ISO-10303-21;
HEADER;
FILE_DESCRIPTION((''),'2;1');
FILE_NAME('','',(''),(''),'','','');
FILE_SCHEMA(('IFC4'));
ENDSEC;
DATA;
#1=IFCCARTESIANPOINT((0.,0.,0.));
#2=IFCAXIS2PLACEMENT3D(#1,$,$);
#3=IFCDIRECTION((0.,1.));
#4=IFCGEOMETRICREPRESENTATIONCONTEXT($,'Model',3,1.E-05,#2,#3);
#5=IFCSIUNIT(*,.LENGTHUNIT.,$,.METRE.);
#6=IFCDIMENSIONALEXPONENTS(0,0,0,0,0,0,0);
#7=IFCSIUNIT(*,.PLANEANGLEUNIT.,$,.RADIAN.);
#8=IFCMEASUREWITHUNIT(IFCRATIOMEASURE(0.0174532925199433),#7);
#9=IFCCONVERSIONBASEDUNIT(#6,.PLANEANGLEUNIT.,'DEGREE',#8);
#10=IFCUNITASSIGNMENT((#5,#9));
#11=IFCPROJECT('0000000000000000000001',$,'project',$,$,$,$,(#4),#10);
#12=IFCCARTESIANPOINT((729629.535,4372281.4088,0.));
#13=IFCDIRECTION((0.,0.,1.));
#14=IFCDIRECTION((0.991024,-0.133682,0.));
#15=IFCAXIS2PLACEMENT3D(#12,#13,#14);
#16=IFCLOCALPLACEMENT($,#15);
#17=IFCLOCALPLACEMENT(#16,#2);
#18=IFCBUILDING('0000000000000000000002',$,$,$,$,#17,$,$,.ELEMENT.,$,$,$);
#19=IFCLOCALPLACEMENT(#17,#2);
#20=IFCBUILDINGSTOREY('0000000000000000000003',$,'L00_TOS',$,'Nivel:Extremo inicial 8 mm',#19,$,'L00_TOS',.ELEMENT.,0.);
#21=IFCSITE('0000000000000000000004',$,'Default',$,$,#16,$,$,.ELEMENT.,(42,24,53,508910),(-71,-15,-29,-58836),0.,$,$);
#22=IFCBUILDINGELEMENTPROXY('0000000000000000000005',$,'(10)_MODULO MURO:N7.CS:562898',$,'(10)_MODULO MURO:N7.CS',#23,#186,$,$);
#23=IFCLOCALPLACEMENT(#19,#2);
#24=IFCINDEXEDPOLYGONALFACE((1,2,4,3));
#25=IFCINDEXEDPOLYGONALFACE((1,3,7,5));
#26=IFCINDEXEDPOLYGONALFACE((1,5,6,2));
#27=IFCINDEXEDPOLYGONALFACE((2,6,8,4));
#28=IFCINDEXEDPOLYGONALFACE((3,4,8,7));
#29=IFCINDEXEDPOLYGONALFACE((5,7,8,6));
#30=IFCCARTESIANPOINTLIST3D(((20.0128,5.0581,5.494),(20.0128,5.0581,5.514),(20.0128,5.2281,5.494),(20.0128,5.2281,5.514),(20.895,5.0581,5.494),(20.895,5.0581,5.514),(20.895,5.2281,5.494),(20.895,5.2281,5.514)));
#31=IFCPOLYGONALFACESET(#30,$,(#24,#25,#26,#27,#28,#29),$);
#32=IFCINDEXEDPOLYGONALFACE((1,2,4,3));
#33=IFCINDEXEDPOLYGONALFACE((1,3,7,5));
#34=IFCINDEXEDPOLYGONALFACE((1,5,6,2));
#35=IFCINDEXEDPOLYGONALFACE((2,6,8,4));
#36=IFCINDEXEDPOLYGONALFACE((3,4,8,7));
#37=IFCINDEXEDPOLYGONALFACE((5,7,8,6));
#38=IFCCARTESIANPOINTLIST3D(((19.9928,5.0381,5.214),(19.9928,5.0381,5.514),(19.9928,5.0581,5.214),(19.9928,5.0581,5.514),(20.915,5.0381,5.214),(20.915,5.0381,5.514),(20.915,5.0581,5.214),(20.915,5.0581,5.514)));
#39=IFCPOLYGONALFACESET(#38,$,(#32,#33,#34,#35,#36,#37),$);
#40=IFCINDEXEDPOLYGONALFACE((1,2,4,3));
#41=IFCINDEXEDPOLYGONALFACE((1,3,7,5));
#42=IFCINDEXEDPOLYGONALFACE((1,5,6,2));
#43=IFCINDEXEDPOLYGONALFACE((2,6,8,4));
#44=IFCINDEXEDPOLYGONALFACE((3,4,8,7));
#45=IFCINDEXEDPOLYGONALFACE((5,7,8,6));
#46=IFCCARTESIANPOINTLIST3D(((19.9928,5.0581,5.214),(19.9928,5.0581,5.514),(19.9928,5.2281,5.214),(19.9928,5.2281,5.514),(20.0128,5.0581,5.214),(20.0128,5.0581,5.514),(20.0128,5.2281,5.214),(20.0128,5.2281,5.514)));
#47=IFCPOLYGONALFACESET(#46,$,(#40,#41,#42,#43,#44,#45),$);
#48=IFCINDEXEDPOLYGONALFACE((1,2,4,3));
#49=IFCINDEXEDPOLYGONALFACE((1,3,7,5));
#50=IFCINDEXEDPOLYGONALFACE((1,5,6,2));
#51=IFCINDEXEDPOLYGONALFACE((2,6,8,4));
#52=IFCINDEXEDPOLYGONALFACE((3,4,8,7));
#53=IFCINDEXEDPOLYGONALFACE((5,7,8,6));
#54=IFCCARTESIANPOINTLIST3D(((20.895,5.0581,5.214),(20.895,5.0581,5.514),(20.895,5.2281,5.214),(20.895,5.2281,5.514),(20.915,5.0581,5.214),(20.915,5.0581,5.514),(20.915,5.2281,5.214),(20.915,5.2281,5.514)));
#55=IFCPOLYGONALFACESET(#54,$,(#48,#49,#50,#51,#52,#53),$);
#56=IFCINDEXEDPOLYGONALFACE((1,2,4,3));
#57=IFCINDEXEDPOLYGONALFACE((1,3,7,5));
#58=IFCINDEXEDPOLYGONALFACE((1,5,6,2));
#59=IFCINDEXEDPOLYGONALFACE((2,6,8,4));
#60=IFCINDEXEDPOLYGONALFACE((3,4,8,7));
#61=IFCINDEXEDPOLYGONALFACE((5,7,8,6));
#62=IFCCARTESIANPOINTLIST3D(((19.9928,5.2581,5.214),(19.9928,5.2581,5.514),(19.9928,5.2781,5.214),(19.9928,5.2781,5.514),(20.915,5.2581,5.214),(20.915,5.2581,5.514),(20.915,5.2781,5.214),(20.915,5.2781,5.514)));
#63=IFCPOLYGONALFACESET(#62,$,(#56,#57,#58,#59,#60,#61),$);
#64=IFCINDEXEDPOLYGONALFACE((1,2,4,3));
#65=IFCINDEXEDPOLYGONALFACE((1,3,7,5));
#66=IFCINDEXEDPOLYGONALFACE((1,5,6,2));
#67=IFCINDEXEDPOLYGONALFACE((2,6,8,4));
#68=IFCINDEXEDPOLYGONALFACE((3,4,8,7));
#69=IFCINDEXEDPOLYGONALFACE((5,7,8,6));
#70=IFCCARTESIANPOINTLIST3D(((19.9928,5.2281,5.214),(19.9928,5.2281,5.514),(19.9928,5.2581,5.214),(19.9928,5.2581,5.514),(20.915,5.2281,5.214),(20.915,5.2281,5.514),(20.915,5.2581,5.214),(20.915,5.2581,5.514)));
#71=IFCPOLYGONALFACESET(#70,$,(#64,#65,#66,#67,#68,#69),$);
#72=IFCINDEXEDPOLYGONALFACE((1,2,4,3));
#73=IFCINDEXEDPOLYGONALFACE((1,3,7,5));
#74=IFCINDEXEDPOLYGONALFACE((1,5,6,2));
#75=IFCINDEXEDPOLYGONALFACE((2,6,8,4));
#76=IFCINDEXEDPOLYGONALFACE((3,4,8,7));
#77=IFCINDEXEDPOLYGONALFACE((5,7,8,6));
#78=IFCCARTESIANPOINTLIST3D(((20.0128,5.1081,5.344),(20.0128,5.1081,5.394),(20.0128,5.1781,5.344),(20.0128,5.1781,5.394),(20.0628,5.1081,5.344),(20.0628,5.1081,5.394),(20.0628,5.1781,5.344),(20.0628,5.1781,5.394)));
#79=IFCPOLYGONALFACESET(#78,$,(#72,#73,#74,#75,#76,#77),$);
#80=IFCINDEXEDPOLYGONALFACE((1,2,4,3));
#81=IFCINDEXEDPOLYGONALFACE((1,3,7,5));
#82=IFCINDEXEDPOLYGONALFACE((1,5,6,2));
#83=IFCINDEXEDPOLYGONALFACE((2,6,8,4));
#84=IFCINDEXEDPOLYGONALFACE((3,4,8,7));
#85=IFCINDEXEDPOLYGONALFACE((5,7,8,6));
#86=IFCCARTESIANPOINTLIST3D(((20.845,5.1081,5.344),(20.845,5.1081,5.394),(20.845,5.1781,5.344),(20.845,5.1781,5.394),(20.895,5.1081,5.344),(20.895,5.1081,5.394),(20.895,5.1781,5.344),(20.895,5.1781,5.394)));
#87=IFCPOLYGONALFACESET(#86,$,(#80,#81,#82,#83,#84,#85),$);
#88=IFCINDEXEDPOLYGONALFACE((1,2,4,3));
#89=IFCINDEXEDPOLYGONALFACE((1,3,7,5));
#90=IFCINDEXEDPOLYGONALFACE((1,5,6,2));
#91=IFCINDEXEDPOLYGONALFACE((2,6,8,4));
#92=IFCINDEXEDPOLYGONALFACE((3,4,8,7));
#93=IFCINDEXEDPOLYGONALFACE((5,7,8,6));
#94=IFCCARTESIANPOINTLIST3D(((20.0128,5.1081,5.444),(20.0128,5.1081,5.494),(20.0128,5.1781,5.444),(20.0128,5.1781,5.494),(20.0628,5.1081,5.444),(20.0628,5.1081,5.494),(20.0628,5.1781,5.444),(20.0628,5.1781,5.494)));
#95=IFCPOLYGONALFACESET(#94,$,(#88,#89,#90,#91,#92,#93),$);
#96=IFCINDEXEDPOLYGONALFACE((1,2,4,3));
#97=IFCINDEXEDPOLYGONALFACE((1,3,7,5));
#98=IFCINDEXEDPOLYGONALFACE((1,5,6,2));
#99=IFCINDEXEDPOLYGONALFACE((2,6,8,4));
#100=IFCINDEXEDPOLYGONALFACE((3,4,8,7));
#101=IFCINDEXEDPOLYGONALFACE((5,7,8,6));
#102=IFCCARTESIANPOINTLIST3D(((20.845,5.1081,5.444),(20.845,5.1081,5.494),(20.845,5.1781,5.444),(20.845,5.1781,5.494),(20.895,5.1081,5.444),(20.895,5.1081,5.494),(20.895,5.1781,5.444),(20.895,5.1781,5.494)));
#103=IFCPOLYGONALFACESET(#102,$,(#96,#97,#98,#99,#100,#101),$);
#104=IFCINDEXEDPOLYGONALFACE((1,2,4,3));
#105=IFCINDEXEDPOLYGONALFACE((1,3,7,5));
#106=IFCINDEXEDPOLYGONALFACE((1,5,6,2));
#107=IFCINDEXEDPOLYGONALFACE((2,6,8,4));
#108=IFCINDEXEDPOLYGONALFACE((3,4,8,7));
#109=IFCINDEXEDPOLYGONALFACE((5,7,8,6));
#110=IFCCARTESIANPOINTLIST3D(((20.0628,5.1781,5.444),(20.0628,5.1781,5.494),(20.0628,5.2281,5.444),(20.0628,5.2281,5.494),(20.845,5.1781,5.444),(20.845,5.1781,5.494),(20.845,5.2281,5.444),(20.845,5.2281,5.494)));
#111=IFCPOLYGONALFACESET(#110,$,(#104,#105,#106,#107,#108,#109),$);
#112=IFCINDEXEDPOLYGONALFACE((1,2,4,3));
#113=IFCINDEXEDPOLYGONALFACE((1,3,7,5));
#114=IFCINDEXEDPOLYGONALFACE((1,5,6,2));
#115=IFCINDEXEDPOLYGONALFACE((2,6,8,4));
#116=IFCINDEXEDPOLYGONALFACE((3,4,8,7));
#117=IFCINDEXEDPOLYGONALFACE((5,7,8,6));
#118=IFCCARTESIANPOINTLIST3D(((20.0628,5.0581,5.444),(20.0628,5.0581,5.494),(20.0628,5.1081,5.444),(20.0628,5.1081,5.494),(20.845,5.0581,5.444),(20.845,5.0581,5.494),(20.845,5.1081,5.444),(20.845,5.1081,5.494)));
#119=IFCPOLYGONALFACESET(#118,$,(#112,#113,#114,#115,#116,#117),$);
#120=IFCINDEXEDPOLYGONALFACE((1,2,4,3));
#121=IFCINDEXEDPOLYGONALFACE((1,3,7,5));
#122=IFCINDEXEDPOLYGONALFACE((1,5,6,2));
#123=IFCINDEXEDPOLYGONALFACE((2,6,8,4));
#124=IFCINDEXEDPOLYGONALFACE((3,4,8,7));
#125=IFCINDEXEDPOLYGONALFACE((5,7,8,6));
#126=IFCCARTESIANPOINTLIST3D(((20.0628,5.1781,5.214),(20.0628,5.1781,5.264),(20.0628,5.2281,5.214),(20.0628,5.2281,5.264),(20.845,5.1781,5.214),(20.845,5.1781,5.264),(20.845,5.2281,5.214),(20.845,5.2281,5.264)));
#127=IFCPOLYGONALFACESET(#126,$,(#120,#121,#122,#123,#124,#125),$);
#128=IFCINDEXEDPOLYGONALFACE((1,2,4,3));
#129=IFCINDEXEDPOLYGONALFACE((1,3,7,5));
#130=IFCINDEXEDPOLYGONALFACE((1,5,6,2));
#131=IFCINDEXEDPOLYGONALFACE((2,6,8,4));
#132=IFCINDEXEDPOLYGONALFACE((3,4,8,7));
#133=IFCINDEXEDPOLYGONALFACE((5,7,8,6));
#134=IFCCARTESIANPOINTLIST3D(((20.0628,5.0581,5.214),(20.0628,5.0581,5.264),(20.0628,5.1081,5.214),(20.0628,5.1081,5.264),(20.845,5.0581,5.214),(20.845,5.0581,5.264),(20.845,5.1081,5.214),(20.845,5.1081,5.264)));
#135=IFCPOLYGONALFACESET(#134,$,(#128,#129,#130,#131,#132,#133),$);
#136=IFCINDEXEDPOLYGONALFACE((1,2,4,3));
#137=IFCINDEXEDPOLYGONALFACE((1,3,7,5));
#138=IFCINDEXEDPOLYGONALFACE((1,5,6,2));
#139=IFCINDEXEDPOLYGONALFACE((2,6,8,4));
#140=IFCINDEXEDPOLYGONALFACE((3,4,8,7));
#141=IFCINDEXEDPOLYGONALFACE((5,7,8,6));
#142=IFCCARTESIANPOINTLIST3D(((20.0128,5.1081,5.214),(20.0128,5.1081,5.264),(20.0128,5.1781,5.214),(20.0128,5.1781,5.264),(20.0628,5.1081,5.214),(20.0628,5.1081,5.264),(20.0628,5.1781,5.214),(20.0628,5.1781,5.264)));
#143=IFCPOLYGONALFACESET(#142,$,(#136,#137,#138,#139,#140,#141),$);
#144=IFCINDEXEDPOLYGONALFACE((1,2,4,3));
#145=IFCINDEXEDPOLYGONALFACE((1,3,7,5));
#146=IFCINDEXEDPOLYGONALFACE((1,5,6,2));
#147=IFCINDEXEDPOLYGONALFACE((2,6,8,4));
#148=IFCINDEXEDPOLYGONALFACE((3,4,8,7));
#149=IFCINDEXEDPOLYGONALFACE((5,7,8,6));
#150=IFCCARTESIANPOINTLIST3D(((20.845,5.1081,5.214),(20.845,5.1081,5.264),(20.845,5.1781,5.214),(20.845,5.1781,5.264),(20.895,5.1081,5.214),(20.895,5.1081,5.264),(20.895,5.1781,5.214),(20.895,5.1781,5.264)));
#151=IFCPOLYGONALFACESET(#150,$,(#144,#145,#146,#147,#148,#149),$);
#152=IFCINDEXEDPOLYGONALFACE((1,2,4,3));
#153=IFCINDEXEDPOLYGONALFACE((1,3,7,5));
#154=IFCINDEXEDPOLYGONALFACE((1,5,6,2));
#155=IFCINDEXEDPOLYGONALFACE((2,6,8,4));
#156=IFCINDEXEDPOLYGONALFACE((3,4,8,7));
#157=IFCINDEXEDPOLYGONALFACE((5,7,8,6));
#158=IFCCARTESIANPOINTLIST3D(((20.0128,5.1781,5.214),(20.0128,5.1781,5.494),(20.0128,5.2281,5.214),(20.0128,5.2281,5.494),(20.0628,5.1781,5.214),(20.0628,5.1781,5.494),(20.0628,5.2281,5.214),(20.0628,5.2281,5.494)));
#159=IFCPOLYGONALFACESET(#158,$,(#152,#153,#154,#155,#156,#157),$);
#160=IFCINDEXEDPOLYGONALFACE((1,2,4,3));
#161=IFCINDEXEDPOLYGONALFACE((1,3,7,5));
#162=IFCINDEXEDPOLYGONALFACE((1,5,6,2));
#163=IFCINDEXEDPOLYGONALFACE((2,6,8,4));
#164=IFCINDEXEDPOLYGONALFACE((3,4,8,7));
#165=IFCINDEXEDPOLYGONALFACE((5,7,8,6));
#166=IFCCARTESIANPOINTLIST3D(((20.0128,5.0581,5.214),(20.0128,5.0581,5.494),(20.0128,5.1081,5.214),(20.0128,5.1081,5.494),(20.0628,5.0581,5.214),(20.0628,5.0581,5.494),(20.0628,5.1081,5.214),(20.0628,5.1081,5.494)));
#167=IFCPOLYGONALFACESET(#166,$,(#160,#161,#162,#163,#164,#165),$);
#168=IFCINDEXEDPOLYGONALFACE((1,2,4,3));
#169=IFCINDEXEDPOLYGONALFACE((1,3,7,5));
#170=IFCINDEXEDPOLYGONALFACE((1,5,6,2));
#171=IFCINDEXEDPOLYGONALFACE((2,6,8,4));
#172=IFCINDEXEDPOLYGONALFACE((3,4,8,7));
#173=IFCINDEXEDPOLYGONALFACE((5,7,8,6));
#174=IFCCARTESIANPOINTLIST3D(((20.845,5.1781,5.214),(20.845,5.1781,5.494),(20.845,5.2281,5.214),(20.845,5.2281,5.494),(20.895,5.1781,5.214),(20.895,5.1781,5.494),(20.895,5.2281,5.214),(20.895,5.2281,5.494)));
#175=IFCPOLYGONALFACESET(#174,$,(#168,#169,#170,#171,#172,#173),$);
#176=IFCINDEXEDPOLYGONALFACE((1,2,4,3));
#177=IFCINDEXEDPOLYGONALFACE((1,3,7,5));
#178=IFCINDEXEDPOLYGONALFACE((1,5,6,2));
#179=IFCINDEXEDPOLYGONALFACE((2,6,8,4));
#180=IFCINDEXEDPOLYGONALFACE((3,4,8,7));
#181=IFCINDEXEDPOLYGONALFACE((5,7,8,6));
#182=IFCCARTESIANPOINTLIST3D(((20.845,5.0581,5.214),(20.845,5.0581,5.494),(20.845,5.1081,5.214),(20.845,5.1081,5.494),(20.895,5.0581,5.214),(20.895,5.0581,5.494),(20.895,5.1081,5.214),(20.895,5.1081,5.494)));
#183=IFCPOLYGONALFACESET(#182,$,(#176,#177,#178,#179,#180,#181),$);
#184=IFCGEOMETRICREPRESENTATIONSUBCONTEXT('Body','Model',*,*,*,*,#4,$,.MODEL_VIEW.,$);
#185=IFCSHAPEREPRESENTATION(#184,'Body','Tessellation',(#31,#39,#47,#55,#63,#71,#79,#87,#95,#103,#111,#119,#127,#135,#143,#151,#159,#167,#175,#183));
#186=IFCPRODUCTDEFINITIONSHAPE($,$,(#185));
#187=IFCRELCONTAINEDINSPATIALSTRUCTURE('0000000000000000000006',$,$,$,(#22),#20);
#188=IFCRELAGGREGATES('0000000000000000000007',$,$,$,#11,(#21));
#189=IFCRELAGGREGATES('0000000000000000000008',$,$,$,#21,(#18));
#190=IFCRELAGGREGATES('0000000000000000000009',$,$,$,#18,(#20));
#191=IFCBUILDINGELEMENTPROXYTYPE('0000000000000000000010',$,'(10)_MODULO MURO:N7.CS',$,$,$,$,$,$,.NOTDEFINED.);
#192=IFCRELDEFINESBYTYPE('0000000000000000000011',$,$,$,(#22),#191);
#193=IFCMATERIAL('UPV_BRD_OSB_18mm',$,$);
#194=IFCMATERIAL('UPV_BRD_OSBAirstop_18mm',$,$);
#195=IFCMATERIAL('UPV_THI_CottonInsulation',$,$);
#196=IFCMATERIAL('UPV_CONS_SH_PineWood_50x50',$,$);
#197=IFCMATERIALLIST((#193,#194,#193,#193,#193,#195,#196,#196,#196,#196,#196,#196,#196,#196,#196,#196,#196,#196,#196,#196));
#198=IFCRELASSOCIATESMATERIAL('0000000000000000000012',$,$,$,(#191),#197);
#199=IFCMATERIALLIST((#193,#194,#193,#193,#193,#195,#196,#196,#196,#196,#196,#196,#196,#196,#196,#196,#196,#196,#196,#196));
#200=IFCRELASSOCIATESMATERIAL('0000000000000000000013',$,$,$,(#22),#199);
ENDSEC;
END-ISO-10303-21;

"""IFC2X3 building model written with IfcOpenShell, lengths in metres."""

from ifc_helpers import new_model, entity, si_unit, converted_unit, direction, frame, frame_2d, origin, origin_2d_with_axis, place, context, subcontext, project, spatial, rectangle, extrude, source, transform, mapped, material, material_list, type_object, type_shapes, element, save


model = new_model("IFC2X3")

# Units and contexts
model_context = context("Model", 3, precision=1e-05, world=origin(), true_north=direction((0.0, 1.0)))
body_context = subcontext(model_context, "Body", "Model", "MODEL_VIEW")
ifc_project = project(units=[si_unit("LENGTHUNIT", "METRE"), converted_unit("PLANEANGLEUNIT", "DEGREE", entity("IfcRatioMeasure", 0.0174532925199433), si_unit("PLANEANGLEUNIT", "RADIAN"), dimensions=[0, 0, 0, 0, 0, 0, 0])], contexts=[model_context])

# Site, building, storey
site_placement = place(None, frame((729629.535, 4372281.4088, 0.0), z_axis=(0.0, 0.0, 1.0), x_axis=(0.991024, -0.133682, 0.0)))
site = spatial("IfcSite", under=ifc_project, at=site_placement, Name="Default", CompositionType="ELEMENT", RefLatitude=(42, 24, 53, 508910), RefLongitude=(-71, -15, -29, -58836), RefElevation=0.0)
building_placement = place(site_placement, origin())
building = spatial("IfcBuilding", under=site, at=building_placement, CompositionType="ELEMENT")
storey_placement = place(building_placement, origin())
storey = spatial("IfcBuildingStorey", under=building, at=storey_placement, Name="L00_TOS", ObjectType="Nivel:Extremo inicial 8 mm", LongName="L00_TOS", CompositionType="ELEMENT", Elevation=0.0)

# Building element proxy
ifc_material_1 = material(Name="UPV_BRD_OSBAirstop_18mm")
ifc_material_2 = material(Name="UPV_BRD_OSB_18mm")
ifc_material_3 = material(Name="UPV_THI_CottonInsulation")
ifc_material_4 = material(Name="UPV_CONS_SH_PineWood_50x50")
ifc_material_list_1 = material_list([ifc_material_2, ifc_material_1, ifc_material_2, ifc_material_2, ifc_material_2, ifc_material_3, ifc_material_4, ifc_material_4, ifc_material_4, ifc_material_4, ifc_material_4, ifc_material_4, ifc_material_4, ifc_material_4, ifc_material_4, ifc_material_4, ifc_material_4, ifc_material_4, ifc_material_4, ifc_material_4])
ifc_material_list_2 = material_list([ifc_material_2, ifc_material_1, ifc_material_2, ifc_material_2, ifc_material_2, ifc_material_3, ifc_material_4, ifc_material_4, ifc_material_4, ifc_material_4, ifc_material_4, ifc_material_4, ifc_material_4, ifc_material_4, ifc_material_4, ifc_material_4, ifc_material_4, ifc_material_4, ifc_material_4, ifc_material_4])
building_element_proxy_type_1 = type_object("IfcBuildingElementProxyType", Name="(10)_MODULO MURO:N7.CS", PredefinedType="NOTDEFINED", material=ifc_material_list_2)
shared_shape_1 = source(origin(), body_context, "Body", "SweptSolid", [
    extrude(rectangle(XDim=0.8822, YDim=0.17, at=origin_2d_with_axis()), frame((0.0, 0.0, 0.28), z_axis=(0.0, 0.0, 1.0), x_axis=(-1.0, 0.0, 0.0)), (0.0, 0.0, 1.0), 0.02),
    extrude(rectangle(XDim=0.9222, YDim=0.02, at=origin_2d_with_axis()), frame((0.0, -0.095, 0.0)), (0.0, 0.0, 1.0), 0.3),
    extrude(rectangle(XDim=0.17, YDim=0.02, at=frame_2d((0.0, 0.0), x_axis=(1.0, 0.0))), frame((-0.4511, 0.0, 0.0), z_axis=(0.0, 0.0, 1.0), x_axis=(0.0, -1.0, 0.0)), (0.0, 0.0, 1.0), 0.3),
    extrude(rectangle(XDim=0.17, YDim=0.02, at=origin_2d_with_axis()), frame((0.4511, 0.0, 0.0), z_axis=(0.0, 0.0, 1.0), x_axis=(0.0, -1.0, 0.0)), (0.0, 0.0, 1.0), 0.3),
    extrude(rectangle(XDim=0.9222, YDim=0.02, at=origin_2d_with_axis()), frame((0.0, 0.125, 0.0), z_axis=(0.0, 0.0, 1.0), x_axis=(-1.0, 0.0, 0.0)), (0.0, 0.0, 1.0), 0.3),
    extrude(rectangle(XDim=0.9222, YDim=0.03, at=frame_2d((0.0, 0.0), x_axis=(1.0, 0.0))), frame((0.0, 0.1, 0.0), z_axis=(0.0, 0.0, 1.0), x_axis=(-1.0, 0.0, 0.0)), (0.0, 0.0, 1.0), 0.3),
    extrude(rectangle(XDim=0.07, YDim=0.05, at=frame_2d((0.0, 0.0), x_axis=(1.0, 0.0))), frame((-0.4161, 0.0, 0.13), z_axis=(0.0, 0.0, 1.0), x_axis=(0.0, 1.0, 0.0)), (0.0, 0.0, 1.0), 0.05),
    extrude(rectangle(XDim=0.07, YDim=0.05, at=origin_2d_with_axis()), frame((0.4161, 0.0, 0.13), z_axis=(0.0, 0.0, 1.0), x_axis=(0.0, 1.0, 0.0)), (0.0, 0.0, 1.0), 0.05),
    extrude(rectangle(XDim=0.07, YDim=0.05, at=frame_2d((0.0, 0.0), x_axis=(1.0, 0.0))), frame((-0.4161, 0.0, 0.23), z_axis=(0.0, 0.0, 1.0), x_axis=(0.0, -1.0, 0.0)), (0.0, 0.0, 1.0), 0.05),
    extrude(rectangle(XDim=0.07, YDim=0.05, at=frame_2d((0.0, 0.0), x_axis=(1.0, 0.0))), frame((0.4161, 0.0, 0.23), z_axis=(0.0, 0.0, 1.0), x_axis=(0.0, -1.0, 0.0)), (0.0, 0.0, 1.0), 0.05),
    extrude(rectangle(XDim=0.7822, YDim=0.05, at=origin_2d_with_axis()), frame((0.0, 0.06, 0.23), z_axis=(0.0, 0.0, 1.0), x_axis=(-1.0, 0.0, 0.0)), (0.0, 0.0, 1.0), 0.05),
    extrude(rectangle(XDim=0.05, YDim=0.7822, at=frame_2d((0.0, 0.0), x_axis=(1.0, 0.0))), frame((0.0, -0.06, 0.23), z_axis=(0.0, 0.0, 1.0), x_axis=(0.0, -1.0, 0.0)), (0.0, 0.0, 1.0), 0.05),
    extrude(rectangle(XDim=0.05, YDim=0.7822, at=origin_2d_with_axis()), frame((0.0, 0.06, 0.0), z_axis=(0.0, 0.0, 1.0), x_axis=(0.0, -1.0, 0.0)), (0.0, 0.0, 1.0), 0.05),
    extrude(rectangle(XDim=0.05, YDim=0.7822, at=frame_2d((0.0, 0.0), x_axis=(1.0, 0.0))), frame((0.0, -0.06, 0.0), z_axis=(0.0, 0.0, 1.0), x_axis=(0.0, -1.0, 0.0)), (0.0, 0.0, 1.0), 0.05),
    extrude(rectangle(XDim=0.07, YDim=0.05, at=frame_2d((0.0, 0.0), x_axis=(1.0, 0.0))), frame((-0.4161, 0.0, 0.0), z_axis=(0.0, 0.0, 1.0), x_axis=(0.0, -1.0, 0.0)), (0.0, 0.0, 1.0), 0.05),
    extrude(rectangle(XDim=0.05, YDim=0.07, at=origin_2d_with_axis()), frame((0.4161, 0.0, 0.0), z_axis=(0.0, 0.0, 1.0), x_axis=(-1.0, 0.0, 0.0)), (0.0, 0.0, 1.0), 0.05),
    extrude(rectangle(XDim=0.05, YDim=0.05, at=frame_2d((0.0, 0.0), x_axis=(1.0, 0.0))), frame((-0.4161, 0.06, 0.0), z_axis=(0.0, 0.0, 1.0), x_axis=(0.0, -1.0, 0.0)), (0.0, 0.0, 1.0), 0.28),
    extrude(rectangle(XDim=0.05, YDim=0.05, at=frame_2d((0.0, 0.0), x_axis=(1.0, 0.0))), frame((-0.4161, -0.06, 0.0), z_axis=(0.0, 0.0, 1.0), x_axis=(0.0, -1.0, 0.0)), (0.0, 0.0, 1.0), 0.28),
    extrude(rectangle(XDim=0.05, YDim=0.05, at=origin_2d_with_axis()), frame((0.4161, 0.06, 0.0), z_axis=(0.0, 0.0, 1.0), x_axis=(0.0, -1.0, 0.0)), (0.0, 0.0, 1.0), 0.28),
    extrude(rectangle(XDim=0.05, YDim=0.05, at=frame_2d((0.0, 0.0), x_axis=(1.0, 0.0))), frame((0.4161, -0.06, 0.0), z_axis=(0.0, 0.0, 1.0), x_axis=(0.0, -1.0, 0.0)), (0.0, 0.0, 1.0), 0.28),
])
type_shapes(building_element_proxy_type_1, [shared_shape_1])
proxy_1_placement = place(storey_placement, frame((20.4539, 5.1431, 5.214)))
element("IfcBuildingElementProxy", 1, at=proxy_1_placement, inside=storey, type_object=building_element_proxy_type_1, material=ifc_material_list_1, Name="(10)_MODULO MURO:N7.CS:562898", ObjectType="(10)_MODULO MURO:N7.CS", context=body_context, shape_type="MappedRepresentation", body=[
    mapped(shared_shape_1, transform((0.0, 0.0, 0.0), scale=1.0)),
])

save(model, "model.ifc")
